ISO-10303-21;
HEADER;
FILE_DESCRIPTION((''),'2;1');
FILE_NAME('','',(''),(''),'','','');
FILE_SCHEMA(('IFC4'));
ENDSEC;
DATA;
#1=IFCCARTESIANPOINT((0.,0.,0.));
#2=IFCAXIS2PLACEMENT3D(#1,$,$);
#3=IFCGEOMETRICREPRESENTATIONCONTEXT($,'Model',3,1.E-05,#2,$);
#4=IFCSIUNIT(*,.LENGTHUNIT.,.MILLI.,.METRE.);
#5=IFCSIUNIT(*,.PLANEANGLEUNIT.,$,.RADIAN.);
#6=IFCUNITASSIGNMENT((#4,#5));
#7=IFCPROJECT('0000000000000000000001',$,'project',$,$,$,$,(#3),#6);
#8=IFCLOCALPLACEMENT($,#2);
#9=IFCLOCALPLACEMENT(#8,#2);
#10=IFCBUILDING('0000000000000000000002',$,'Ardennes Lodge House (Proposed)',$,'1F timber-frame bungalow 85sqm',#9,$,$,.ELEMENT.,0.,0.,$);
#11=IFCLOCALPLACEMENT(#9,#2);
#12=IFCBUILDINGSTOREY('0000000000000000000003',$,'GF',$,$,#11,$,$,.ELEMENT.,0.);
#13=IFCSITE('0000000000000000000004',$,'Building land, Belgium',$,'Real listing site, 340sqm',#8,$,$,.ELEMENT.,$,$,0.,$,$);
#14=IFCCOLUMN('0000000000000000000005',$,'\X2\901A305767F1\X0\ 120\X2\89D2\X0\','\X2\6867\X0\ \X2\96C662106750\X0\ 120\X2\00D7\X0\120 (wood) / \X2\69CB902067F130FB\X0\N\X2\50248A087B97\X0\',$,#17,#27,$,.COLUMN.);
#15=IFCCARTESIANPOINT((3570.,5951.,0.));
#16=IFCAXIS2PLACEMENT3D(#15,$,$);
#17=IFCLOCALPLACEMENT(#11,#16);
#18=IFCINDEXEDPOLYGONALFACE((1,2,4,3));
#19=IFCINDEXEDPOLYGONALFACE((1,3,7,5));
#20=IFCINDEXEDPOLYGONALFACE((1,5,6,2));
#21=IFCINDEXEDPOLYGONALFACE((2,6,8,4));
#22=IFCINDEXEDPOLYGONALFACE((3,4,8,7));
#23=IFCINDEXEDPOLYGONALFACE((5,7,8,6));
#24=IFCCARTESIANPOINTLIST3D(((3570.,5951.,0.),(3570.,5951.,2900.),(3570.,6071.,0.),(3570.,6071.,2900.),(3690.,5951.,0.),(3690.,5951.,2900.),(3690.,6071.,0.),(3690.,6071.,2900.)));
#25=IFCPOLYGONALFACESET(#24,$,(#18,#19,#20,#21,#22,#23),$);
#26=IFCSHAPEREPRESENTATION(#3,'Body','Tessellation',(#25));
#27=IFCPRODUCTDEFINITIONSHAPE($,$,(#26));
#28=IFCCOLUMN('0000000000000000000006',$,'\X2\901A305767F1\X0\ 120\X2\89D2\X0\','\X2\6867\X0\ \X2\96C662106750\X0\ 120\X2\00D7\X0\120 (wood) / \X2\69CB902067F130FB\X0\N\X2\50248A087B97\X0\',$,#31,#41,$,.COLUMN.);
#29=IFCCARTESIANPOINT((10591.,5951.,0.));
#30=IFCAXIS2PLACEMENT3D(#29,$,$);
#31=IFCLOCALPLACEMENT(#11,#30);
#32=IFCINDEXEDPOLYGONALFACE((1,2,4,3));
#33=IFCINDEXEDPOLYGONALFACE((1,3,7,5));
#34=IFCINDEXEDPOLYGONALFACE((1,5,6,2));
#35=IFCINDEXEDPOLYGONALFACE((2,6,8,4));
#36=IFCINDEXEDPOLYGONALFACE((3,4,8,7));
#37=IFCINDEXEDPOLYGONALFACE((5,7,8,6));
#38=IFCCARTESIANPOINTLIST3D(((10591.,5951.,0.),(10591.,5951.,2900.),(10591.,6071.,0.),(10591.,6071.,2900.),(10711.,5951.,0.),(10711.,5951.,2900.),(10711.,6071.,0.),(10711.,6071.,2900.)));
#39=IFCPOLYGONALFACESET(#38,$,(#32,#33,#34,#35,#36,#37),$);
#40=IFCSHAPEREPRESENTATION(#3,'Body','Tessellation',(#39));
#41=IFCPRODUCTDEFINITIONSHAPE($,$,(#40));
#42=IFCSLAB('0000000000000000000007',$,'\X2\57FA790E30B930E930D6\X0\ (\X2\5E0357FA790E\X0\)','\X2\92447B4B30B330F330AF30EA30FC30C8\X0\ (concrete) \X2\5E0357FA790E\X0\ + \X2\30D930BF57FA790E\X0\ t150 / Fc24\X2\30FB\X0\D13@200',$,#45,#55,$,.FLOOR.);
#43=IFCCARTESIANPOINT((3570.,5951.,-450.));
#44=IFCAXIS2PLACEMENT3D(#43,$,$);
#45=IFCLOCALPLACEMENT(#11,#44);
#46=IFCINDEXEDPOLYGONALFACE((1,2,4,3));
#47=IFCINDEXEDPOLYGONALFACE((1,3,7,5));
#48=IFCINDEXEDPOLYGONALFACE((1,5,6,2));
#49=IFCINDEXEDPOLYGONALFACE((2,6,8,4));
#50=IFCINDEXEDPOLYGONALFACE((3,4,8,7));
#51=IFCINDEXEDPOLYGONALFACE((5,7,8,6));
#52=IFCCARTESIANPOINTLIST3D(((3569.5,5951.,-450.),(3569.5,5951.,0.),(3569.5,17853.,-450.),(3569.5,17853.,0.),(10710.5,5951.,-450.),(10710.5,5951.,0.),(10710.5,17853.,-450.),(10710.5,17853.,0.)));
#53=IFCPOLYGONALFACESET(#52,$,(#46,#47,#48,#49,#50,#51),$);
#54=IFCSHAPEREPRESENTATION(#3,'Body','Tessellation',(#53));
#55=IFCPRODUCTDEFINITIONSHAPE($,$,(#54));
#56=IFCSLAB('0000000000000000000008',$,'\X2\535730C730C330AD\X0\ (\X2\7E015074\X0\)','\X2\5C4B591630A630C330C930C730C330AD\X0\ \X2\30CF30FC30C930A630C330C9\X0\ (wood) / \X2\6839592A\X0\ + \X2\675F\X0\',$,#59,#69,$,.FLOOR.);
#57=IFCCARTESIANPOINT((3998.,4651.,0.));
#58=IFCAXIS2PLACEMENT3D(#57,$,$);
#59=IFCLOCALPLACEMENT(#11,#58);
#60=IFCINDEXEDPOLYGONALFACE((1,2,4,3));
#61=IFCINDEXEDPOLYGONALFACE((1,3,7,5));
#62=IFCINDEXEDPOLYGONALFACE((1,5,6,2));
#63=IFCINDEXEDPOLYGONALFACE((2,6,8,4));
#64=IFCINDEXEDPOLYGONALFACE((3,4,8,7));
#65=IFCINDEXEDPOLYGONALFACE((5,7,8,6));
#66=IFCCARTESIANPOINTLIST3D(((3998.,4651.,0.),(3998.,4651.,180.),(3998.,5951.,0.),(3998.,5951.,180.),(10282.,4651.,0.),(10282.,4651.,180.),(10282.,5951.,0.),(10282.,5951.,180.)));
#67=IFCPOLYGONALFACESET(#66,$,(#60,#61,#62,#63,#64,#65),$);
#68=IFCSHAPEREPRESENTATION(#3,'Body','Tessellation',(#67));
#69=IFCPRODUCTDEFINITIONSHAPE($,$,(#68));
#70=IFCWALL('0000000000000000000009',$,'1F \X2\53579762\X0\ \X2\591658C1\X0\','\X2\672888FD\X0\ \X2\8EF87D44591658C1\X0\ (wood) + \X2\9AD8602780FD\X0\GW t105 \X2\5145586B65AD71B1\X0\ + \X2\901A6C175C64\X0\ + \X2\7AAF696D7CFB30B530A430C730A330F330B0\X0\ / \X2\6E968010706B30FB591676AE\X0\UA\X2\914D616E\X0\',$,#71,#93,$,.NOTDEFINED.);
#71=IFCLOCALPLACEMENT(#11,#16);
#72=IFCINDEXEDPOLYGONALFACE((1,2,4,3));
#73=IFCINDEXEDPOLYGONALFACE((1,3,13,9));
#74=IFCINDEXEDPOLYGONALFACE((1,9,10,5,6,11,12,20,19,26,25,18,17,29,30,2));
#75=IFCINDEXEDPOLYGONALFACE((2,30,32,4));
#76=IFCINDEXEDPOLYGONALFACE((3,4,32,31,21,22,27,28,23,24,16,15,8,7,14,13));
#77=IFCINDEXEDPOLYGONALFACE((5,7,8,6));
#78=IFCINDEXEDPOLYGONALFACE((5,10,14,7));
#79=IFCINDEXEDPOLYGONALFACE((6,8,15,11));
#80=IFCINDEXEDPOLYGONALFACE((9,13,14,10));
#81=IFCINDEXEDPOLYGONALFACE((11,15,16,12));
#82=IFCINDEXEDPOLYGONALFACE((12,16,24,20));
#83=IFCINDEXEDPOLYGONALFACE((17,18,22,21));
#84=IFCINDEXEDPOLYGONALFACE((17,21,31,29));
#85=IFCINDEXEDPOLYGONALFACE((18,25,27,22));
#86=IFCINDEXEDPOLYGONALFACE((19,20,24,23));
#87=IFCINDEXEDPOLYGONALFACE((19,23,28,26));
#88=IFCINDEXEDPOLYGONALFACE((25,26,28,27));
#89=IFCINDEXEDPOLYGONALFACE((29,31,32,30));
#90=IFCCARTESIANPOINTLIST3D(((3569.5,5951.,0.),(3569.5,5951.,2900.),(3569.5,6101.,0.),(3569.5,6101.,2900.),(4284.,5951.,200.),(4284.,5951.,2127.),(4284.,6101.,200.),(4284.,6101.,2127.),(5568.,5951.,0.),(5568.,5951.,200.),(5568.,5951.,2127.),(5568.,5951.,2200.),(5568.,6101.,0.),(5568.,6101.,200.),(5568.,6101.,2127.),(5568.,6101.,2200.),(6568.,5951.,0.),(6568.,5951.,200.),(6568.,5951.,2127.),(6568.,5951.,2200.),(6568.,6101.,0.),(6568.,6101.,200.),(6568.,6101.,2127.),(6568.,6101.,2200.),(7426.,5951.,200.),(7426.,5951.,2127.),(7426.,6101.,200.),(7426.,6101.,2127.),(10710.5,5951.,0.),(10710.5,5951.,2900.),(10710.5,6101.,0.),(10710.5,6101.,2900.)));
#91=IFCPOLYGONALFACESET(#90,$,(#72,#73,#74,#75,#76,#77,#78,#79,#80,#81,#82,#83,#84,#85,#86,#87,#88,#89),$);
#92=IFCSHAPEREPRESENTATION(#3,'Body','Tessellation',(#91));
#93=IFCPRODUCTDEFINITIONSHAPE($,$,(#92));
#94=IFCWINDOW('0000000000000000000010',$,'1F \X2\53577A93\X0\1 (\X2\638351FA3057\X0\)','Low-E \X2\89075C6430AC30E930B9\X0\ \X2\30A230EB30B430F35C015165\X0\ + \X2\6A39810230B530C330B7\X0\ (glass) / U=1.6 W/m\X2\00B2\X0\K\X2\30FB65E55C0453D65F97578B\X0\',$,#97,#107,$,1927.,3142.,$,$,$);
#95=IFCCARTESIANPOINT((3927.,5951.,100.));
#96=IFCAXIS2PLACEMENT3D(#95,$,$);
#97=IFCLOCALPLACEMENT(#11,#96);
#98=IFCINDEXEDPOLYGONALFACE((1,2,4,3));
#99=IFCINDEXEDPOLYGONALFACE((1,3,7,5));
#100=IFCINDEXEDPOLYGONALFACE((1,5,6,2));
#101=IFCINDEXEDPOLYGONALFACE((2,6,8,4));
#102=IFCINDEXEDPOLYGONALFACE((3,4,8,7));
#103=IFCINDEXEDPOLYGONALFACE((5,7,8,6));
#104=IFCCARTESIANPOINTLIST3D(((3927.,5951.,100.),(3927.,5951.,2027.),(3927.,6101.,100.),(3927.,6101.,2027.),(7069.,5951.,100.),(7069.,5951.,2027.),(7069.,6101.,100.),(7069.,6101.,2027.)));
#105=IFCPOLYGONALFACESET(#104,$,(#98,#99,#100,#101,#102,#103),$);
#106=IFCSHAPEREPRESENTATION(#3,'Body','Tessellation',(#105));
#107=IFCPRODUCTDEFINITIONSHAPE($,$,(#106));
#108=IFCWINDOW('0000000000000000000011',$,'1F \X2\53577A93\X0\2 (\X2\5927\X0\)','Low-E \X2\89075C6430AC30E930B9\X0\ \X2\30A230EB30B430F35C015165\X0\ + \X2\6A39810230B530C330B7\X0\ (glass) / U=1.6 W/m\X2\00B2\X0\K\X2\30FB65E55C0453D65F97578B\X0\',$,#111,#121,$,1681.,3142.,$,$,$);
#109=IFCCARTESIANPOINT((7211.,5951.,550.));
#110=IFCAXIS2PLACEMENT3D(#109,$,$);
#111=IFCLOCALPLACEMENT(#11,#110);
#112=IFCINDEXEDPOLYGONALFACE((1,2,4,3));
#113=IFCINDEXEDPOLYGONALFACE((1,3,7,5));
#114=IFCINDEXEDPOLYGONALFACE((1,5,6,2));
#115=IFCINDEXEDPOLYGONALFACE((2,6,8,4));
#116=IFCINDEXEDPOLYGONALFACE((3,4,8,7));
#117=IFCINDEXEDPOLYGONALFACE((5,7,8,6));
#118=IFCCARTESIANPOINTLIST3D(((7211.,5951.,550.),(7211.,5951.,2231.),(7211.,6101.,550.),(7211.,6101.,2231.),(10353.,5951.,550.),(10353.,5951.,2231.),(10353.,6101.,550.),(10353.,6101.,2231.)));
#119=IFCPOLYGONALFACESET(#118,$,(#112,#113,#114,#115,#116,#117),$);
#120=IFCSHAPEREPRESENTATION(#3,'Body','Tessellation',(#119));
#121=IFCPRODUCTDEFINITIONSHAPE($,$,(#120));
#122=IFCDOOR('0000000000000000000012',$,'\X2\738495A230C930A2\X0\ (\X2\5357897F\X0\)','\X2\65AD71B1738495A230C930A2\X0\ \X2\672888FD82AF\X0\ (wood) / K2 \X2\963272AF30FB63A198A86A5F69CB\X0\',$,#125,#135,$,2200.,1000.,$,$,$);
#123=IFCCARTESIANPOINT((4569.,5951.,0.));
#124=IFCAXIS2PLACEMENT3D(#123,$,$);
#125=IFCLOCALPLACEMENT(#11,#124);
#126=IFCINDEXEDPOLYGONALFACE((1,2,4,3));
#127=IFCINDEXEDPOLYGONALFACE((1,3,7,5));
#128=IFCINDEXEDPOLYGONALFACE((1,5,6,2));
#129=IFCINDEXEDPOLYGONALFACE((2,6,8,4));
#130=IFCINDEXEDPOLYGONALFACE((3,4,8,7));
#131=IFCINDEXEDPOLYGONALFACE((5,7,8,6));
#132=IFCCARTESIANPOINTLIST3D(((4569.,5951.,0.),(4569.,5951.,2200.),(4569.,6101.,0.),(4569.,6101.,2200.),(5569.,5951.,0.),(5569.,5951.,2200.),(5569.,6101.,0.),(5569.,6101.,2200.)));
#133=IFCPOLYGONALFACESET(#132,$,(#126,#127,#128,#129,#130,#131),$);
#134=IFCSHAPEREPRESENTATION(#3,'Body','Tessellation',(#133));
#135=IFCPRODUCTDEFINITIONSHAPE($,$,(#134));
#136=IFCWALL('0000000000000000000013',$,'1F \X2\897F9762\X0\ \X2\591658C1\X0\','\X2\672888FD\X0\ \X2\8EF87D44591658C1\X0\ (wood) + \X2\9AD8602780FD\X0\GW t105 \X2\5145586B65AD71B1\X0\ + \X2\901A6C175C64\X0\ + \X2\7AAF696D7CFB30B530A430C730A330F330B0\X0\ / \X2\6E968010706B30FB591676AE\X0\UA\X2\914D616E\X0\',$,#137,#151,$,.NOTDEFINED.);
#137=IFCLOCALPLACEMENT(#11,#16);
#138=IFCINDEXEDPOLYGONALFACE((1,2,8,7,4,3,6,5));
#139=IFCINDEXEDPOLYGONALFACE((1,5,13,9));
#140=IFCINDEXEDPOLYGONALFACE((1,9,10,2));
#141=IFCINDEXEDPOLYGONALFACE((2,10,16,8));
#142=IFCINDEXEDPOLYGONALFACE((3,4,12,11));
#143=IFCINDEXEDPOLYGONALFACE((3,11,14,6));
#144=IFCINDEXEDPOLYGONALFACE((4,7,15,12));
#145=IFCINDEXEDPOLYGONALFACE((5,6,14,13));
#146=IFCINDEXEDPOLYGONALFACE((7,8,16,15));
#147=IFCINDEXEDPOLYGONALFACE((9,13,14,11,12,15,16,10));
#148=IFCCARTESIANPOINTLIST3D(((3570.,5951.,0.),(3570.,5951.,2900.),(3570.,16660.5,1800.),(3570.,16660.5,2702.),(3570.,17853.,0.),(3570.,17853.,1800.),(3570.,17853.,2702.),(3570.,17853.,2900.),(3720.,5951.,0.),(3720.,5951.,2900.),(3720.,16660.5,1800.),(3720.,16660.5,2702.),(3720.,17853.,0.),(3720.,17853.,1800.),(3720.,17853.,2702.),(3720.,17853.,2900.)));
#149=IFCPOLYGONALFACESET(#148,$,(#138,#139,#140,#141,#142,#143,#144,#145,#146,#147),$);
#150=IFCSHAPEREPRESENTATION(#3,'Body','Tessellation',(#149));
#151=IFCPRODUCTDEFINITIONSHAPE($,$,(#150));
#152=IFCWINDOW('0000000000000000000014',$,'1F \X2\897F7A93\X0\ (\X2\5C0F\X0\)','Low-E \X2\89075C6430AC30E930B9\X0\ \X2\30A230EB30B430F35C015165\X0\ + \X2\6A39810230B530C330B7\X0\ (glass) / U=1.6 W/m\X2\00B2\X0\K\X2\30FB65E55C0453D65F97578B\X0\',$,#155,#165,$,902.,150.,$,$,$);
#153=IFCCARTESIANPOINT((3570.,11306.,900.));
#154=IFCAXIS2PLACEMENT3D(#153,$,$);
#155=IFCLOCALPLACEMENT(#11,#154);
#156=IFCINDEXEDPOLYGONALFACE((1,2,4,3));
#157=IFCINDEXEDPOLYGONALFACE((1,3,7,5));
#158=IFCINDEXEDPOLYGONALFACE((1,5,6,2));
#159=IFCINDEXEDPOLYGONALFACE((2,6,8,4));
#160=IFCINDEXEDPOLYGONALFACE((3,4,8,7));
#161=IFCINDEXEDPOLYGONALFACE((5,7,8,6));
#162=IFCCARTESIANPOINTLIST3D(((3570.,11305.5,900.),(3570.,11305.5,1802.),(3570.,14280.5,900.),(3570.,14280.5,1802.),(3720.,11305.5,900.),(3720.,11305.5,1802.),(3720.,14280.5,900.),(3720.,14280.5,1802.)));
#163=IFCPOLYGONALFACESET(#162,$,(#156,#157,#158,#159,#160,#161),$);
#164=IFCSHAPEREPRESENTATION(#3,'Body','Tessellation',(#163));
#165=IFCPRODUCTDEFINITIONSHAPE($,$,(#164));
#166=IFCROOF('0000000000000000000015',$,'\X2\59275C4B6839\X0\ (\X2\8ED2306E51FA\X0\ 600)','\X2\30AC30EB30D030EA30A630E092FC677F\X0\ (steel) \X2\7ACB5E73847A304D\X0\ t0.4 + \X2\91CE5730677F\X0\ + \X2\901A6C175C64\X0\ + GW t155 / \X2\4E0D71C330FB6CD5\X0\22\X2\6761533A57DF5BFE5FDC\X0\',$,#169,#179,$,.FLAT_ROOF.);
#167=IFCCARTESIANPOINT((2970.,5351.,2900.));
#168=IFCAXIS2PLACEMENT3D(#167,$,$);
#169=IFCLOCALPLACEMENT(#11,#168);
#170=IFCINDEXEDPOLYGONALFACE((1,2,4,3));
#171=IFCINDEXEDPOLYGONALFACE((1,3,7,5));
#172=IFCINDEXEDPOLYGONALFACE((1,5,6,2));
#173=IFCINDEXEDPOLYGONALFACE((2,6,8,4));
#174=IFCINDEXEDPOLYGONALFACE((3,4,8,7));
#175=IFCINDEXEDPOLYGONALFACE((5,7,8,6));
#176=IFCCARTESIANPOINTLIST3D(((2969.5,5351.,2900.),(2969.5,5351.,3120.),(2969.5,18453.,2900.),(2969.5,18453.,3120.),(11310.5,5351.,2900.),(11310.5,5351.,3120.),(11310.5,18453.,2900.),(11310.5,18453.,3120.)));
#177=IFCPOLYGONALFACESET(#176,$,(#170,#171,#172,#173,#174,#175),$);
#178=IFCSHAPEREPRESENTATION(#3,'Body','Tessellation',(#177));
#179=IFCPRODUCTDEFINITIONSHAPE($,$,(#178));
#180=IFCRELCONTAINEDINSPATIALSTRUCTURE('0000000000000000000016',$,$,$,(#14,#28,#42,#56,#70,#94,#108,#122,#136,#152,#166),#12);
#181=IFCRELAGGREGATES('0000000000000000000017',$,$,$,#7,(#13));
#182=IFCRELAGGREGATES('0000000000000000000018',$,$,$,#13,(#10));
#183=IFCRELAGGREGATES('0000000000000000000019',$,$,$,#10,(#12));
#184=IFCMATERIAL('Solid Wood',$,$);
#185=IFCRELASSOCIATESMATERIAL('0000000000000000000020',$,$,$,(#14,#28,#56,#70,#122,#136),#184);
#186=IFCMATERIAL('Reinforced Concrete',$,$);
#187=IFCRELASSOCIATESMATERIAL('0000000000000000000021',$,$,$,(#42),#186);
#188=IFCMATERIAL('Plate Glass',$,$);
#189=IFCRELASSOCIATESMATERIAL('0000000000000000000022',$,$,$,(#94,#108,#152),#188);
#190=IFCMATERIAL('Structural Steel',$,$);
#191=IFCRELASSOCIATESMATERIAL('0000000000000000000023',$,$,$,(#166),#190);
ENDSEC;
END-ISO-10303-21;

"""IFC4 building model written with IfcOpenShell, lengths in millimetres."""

from ifc_helpers import new_model, si_unit, frame, frame_2d, origin, place, context, project, spatial, rectangle, extrude, material, element, fill, save


model = new_model("IFC4")

# Units and contexts
model_context = context("Model", 3, precision=1e-05, world=origin())
ifc_project = project(units=[si_unit("LENGTHUNIT", "METRE", prefix="MILLI"), si_unit("PLANEANGLEUNIT", "RADIAN")], contexts=[model_context])

# Site, building, storey
site_placement = place(None, origin())
site = spatial("IfcSite", under=ifc_project, at=site_placement, Name="Building land, Belgium", ObjectType="Real listing site, 340sqm", CompositionType="ELEMENT", RefElevation=0.0)
building_placement = place(site_placement, origin())
building = spatial("IfcBuilding", under=site, at=building_placement, Name="Ardennes Lodge House (Proposed)", ObjectType="1F timber-frame bungalow 85sqm", CompositionType="ELEMENT", ElevationOfRefHeight=0.0, ElevationOfTerrain=0.0)
storey_placement = place(building_placement, origin())
storey = spatial("IfcBuildingStorey", under=building, at=storey_placement, Name="GF", CompositionType="ELEMENT", Elevation=0.0)

# Columns
ifc_material_1 = material(Name="Solid Wood")
column_1_placement = place(storey_placement, frame((3570.0, 5951.0, 0.0)))
element("IfcColumn", 1, at=column_1_placement, inside=storey, material=ifc_material_1, Name="通し柱 120角", Description="桧 集成材 120×120 (wood) / 構造柱・N値計算", PredefinedType="COLUMN", context=model_context, shape_type="SweptSolid", body=[
    extrude(rectangle(XDim=120.0, YDim=120.0, at=frame_2d((60.0, 60.0))), frame((3570.0, 5951.0, 0.0)), (0.0, 0.0, 1.0), 2900.0),
])
column_2_placement = place(storey_placement, frame((10591.0, 5951.0, 0.0)))
element("IfcColumn", 2, at=column_2_placement, inside=storey, material=ifc_material_1, Name="通し柱 120角", Description="桧 集成材 120×120 (wood) / 構造柱・N値計算", PredefinedType="COLUMN", context=model_context, shape_type="SweptSolid", body=[
    extrude(rectangle(XDim=120.0, YDim=120.0, at=frame_2d((60.0, 60.0))), frame((10591.0, 5951.0, 0.0)), (0.0, 0.0, 1.0), 2900.0),
])

# Slabs
ifc_material_2 = material(Name="Reinforced Concrete")
slab_1_placement = place(storey_placement, frame((3570.0, 5951.0, -450.0)))
element("IfcSlab", 3, at=slab_1_placement, inside=storey, material=ifc_material_2, Name="基礎スラブ (布基礎)", Description="鉄筋コンクリート (concrete) 布基礎 + ベタ基礎 t150 / Fc24・D13@200", PredefinedType="FLOOR", context=model_context, shape_type="SweptSolid", body=[
    extrude(rectangle(XDim=7141.0, YDim=11902.0, at=frame_2d((3570.0, 5951.0))), frame((3570.0, 5951.0, -450.0)), (0.0, 0.0, 1.0), 450.0),
])
slab_2_placement = place(storey_placement, frame((3998.0, 4651.0, 0.0)))
element("IfcSlab", 4, at=slab_2_placement, inside=storey, material=ifc_material_1, Name="南デッキ (縁側)", Description="屋外ウッドデッキ ハードウッド (wood) / 根太 + 束", PredefinedType="FLOOR", context=model_context, shape_type="SweptSolid", body=[
    extrude(rectangle(XDim=6284.0, YDim=1300.0, at=frame_2d((3142.0, 650.0))), frame((3998.0, 4651.0, 0.0)), (0.0, 0.0, 1.0), 180.0),
])

# Wall, openings, windows, door
wall_1_placement = place(storey_placement, frame((3570.0, 5951.0, 0.0)))
wall_1 = element("IfcWall", 5, at=wall_1_placement, inside=storey, material=ifc_material_1, Name="1F 南面 外壁", Description="木製 軸組外壁 (wood) + 高性能GW t105 充填断熱 + 通気層 + 窯業系サイディング / 準耐火・外皮UA配慮", PredefinedType="NOTDEFINED", context=model_context, shape_type="SweptSolid", body=[
    extrude(rectangle(XDim=7141.0, YDim=150.0, at=frame_2d((3570.0, 75.0))), frame((3570.0, 5951.0, 0.0)), (0.0, 0.0, 1.0), 2900.0),
])
opening_1_placement = place(storey_placement, frame((3927.0, 5951.0, 100.0)))
opening_1 = element("IfcOpeningElement", 6, at=opening_1_placement, cuts=wall_1, PredefinedType="NOTDEFINED", context=model_context, shape_type="SweptSolid", body=[
    extrude(rectangle(XDim=3142.0, YDim=150.0, at=frame_2d((1571.0, 75.0))), frame((3927.0, 5951.0, 100.0)), (0.0, 0.0, 1.0), 1927.0),
])
opening_2_placement = place(storey_placement, frame((7211.0, 5951.0, 550.0)))
opening_2 = element("IfcOpeningElement", 7, at=opening_2_placement, cuts=wall_1, PredefinedType="NOTDEFINED", context=model_context, shape_type="SweptSolid", body=[
    extrude(rectangle(XDim=3142.0, YDim=150.0, at=frame_2d((1571.0, 75.0))), frame((7211.0, 5951.0, 550.0)), (0.0, 0.0, 1.0), 1681.0),
])
opening_3_placement = place(storey_placement, frame((4569.0, 5951.0, 0.0)))
opening_3 = element("IfcOpeningElement", 8, at=opening_3_placement, cuts=wall_1, PredefinedType="NOTDEFINED", context=model_context, shape_type="SweptSolid", body=[
    extrude(rectangle(XDim=1000.0, YDim=150.0, at=frame_2d((500.0, 75.0))), frame((4569.0, 5951.0, 0.0)), (0.0, 0.0, 1.0), 2200.0),
])
ifc_material_3 = material(Name="Plate Glass")
window_1_placement = place(storey_placement, frame((3927.0, 5951.0, 100.0)))
window_1 = element("IfcWindow", 9, at=window_1_placement, inside=storey, material=ifc_material_3, Name="1F 南窓1 (掃出し)", Description="Low-E 複層ガラス アルゴン封入 + 樹脂サッシ (glass) / U=1.6 W/m²K・日射取得型", OverallHeight=1927.0, OverallWidth=3142.0, context=model_context, shape_type="SweptSolid", body=[
    extrude(rectangle(XDim=3142.0, YDim=150.0, at=frame_2d((1571.0, 75.0))), frame((3927.0, 5951.0, 100.0)), (0.0, 0.0, 1.0), 1927.0),
])
fill(opening_1, window_1)
window_2_placement = place(storey_placement, frame((7211.0, 5951.0, 550.0)))
window_2 = element("IfcWindow", 10, at=window_2_placement, inside=storey, material=ifc_material_3, Name="1F 南窓2 (大)", Description="Low-E 複層ガラス アルゴン封入 + 樹脂サッシ (glass) / U=1.6 W/m²K・日射取得型", OverallHeight=1681.0, OverallWidth=3142.0, context=model_context, shape_type="SweptSolid", body=[
    extrude(rectangle(XDim=3142.0, YDim=150.0, at=frame_2d((1571.0, 75.0))), frame((7211.0, 5951.0, 550.0)), (0.0, 0.0, 1.0), 1681.0),
])
fill(opening_2, window_2)
door_placement = place(storey_placement, frame((4569.0, 5951.0, 0.0)))
door = element("IfcDoor", 11, at=door_placement, inside=storey, material=ifc_material_1, Name="玄関ドア (南西)", Description="断熱玄関ドア 木製芯 (wood) / K2 防犯・採風機構", OverallHeight=2200.0, OverallWidth=1000.0, context=model_context, shape_type="SweptSolid", body=[
    extrude(rectangle(XDim=1000.0, YDim=150.0, at=frame_2d((500.0, 75.0))), frame((4569.0, 5951.0, 0.0)), (0.0, 0.0, 1.0), 2200.0),
])
fill(opening_3, door)

# Wall, opening, window
wall_2_placement = place(storey_placement, frame((3570.0, 5951.0, 0.0)))
wall_2 = element("IfcWall", 12, at=wall_2_placement, inside=storey, material=ifc_material_1, Name="1F 西面 外壁", Description="木製 軸組外壁 (wood) + 高性能GW t105 充填断熱 + 通気層 + 窯業系サイディング / 準耐火・外皮UA配慮", PredefinedType="NOTDEFINED", context=model_context, shape_type="SweptSolid", body=[
    extrude(rectangle(XDim=150.0, YDim=11902.0, at=frame_2d((75.0, 5951.0))), frame((3570.0, 5951.0, 0.0)), (0.0, 0.0, 1.0), 2900.0),
])
opening_4_placement = place(storey_placement, frame((3570.0, 11306.0, 900.0)))
opening_4 = element("IfcOpeningElement", 13, at=opening_4_placement, cuts=wall_2, PredefinedType="NOTDEFINED", context=model_context, shape_type="SweptSolid", body=[
    extrude(rectangle(XDim=150.0, YDim=2975.0, at=frame_2d((75.0, 1487.0))), frame((3570.0, 11306.0, 900.0)), (0.0, 0.0, 1.0), 902.0),
])
window_3_placement = place(storey_placement, frame((3570.0, 11306.0, 900.0)))
window_3 = element("IfcWindow", 14, at=window_3_placement, inside=storey, material=ifc_material_3, Name="1F 西窓 (小)", Description="Low-E 複層ガラス アルゴン封入 + 樹脂サッシ (glass) / U=1.6 W/m²K・日射取得型", OverallHeight=902.0, OverallWidth=150.0, context=model_context, shape_type="SweptSolid", body=[
    extrude(rectangle(XDim=150.0, YDim=2975.0, at=frame_2d((75.0, 1487.0))), frame((3570.0, 11306.0, 900.0)), (0.0, 0.0, 1.0), 902.0),
])
fill(opening_4, window_3)

# Roof
ifc_material_4 = material(Name="Structural Steel")
roof_placement = place(storey_placement, frame((2970.0, 5351.0, 2900.0)))
element("IfcRoof", 15, at=roof_placement, inside=storey, material=ifc_material_4, Name="大屋根 (軒の出 600)", Description="ガルバリウム鋼板 (steel) 立平葺き t0.4 + 野地板 + 通気層 + GW t155 / 不燃・法22条区域対応", PredefinedType="FLAT_ROOF", context=model_context, shape_type="SweptSolid", body=[
    extrude(rectangle(XDim=8341.0, YDim=13102.0, at=frame_2d((4170.0, 6551.0))), frame((2970.0, 5351.0, 2900.0)), (0.0, 0.0, 1.0), 220.0),
])

save(model, "model.ifc")
